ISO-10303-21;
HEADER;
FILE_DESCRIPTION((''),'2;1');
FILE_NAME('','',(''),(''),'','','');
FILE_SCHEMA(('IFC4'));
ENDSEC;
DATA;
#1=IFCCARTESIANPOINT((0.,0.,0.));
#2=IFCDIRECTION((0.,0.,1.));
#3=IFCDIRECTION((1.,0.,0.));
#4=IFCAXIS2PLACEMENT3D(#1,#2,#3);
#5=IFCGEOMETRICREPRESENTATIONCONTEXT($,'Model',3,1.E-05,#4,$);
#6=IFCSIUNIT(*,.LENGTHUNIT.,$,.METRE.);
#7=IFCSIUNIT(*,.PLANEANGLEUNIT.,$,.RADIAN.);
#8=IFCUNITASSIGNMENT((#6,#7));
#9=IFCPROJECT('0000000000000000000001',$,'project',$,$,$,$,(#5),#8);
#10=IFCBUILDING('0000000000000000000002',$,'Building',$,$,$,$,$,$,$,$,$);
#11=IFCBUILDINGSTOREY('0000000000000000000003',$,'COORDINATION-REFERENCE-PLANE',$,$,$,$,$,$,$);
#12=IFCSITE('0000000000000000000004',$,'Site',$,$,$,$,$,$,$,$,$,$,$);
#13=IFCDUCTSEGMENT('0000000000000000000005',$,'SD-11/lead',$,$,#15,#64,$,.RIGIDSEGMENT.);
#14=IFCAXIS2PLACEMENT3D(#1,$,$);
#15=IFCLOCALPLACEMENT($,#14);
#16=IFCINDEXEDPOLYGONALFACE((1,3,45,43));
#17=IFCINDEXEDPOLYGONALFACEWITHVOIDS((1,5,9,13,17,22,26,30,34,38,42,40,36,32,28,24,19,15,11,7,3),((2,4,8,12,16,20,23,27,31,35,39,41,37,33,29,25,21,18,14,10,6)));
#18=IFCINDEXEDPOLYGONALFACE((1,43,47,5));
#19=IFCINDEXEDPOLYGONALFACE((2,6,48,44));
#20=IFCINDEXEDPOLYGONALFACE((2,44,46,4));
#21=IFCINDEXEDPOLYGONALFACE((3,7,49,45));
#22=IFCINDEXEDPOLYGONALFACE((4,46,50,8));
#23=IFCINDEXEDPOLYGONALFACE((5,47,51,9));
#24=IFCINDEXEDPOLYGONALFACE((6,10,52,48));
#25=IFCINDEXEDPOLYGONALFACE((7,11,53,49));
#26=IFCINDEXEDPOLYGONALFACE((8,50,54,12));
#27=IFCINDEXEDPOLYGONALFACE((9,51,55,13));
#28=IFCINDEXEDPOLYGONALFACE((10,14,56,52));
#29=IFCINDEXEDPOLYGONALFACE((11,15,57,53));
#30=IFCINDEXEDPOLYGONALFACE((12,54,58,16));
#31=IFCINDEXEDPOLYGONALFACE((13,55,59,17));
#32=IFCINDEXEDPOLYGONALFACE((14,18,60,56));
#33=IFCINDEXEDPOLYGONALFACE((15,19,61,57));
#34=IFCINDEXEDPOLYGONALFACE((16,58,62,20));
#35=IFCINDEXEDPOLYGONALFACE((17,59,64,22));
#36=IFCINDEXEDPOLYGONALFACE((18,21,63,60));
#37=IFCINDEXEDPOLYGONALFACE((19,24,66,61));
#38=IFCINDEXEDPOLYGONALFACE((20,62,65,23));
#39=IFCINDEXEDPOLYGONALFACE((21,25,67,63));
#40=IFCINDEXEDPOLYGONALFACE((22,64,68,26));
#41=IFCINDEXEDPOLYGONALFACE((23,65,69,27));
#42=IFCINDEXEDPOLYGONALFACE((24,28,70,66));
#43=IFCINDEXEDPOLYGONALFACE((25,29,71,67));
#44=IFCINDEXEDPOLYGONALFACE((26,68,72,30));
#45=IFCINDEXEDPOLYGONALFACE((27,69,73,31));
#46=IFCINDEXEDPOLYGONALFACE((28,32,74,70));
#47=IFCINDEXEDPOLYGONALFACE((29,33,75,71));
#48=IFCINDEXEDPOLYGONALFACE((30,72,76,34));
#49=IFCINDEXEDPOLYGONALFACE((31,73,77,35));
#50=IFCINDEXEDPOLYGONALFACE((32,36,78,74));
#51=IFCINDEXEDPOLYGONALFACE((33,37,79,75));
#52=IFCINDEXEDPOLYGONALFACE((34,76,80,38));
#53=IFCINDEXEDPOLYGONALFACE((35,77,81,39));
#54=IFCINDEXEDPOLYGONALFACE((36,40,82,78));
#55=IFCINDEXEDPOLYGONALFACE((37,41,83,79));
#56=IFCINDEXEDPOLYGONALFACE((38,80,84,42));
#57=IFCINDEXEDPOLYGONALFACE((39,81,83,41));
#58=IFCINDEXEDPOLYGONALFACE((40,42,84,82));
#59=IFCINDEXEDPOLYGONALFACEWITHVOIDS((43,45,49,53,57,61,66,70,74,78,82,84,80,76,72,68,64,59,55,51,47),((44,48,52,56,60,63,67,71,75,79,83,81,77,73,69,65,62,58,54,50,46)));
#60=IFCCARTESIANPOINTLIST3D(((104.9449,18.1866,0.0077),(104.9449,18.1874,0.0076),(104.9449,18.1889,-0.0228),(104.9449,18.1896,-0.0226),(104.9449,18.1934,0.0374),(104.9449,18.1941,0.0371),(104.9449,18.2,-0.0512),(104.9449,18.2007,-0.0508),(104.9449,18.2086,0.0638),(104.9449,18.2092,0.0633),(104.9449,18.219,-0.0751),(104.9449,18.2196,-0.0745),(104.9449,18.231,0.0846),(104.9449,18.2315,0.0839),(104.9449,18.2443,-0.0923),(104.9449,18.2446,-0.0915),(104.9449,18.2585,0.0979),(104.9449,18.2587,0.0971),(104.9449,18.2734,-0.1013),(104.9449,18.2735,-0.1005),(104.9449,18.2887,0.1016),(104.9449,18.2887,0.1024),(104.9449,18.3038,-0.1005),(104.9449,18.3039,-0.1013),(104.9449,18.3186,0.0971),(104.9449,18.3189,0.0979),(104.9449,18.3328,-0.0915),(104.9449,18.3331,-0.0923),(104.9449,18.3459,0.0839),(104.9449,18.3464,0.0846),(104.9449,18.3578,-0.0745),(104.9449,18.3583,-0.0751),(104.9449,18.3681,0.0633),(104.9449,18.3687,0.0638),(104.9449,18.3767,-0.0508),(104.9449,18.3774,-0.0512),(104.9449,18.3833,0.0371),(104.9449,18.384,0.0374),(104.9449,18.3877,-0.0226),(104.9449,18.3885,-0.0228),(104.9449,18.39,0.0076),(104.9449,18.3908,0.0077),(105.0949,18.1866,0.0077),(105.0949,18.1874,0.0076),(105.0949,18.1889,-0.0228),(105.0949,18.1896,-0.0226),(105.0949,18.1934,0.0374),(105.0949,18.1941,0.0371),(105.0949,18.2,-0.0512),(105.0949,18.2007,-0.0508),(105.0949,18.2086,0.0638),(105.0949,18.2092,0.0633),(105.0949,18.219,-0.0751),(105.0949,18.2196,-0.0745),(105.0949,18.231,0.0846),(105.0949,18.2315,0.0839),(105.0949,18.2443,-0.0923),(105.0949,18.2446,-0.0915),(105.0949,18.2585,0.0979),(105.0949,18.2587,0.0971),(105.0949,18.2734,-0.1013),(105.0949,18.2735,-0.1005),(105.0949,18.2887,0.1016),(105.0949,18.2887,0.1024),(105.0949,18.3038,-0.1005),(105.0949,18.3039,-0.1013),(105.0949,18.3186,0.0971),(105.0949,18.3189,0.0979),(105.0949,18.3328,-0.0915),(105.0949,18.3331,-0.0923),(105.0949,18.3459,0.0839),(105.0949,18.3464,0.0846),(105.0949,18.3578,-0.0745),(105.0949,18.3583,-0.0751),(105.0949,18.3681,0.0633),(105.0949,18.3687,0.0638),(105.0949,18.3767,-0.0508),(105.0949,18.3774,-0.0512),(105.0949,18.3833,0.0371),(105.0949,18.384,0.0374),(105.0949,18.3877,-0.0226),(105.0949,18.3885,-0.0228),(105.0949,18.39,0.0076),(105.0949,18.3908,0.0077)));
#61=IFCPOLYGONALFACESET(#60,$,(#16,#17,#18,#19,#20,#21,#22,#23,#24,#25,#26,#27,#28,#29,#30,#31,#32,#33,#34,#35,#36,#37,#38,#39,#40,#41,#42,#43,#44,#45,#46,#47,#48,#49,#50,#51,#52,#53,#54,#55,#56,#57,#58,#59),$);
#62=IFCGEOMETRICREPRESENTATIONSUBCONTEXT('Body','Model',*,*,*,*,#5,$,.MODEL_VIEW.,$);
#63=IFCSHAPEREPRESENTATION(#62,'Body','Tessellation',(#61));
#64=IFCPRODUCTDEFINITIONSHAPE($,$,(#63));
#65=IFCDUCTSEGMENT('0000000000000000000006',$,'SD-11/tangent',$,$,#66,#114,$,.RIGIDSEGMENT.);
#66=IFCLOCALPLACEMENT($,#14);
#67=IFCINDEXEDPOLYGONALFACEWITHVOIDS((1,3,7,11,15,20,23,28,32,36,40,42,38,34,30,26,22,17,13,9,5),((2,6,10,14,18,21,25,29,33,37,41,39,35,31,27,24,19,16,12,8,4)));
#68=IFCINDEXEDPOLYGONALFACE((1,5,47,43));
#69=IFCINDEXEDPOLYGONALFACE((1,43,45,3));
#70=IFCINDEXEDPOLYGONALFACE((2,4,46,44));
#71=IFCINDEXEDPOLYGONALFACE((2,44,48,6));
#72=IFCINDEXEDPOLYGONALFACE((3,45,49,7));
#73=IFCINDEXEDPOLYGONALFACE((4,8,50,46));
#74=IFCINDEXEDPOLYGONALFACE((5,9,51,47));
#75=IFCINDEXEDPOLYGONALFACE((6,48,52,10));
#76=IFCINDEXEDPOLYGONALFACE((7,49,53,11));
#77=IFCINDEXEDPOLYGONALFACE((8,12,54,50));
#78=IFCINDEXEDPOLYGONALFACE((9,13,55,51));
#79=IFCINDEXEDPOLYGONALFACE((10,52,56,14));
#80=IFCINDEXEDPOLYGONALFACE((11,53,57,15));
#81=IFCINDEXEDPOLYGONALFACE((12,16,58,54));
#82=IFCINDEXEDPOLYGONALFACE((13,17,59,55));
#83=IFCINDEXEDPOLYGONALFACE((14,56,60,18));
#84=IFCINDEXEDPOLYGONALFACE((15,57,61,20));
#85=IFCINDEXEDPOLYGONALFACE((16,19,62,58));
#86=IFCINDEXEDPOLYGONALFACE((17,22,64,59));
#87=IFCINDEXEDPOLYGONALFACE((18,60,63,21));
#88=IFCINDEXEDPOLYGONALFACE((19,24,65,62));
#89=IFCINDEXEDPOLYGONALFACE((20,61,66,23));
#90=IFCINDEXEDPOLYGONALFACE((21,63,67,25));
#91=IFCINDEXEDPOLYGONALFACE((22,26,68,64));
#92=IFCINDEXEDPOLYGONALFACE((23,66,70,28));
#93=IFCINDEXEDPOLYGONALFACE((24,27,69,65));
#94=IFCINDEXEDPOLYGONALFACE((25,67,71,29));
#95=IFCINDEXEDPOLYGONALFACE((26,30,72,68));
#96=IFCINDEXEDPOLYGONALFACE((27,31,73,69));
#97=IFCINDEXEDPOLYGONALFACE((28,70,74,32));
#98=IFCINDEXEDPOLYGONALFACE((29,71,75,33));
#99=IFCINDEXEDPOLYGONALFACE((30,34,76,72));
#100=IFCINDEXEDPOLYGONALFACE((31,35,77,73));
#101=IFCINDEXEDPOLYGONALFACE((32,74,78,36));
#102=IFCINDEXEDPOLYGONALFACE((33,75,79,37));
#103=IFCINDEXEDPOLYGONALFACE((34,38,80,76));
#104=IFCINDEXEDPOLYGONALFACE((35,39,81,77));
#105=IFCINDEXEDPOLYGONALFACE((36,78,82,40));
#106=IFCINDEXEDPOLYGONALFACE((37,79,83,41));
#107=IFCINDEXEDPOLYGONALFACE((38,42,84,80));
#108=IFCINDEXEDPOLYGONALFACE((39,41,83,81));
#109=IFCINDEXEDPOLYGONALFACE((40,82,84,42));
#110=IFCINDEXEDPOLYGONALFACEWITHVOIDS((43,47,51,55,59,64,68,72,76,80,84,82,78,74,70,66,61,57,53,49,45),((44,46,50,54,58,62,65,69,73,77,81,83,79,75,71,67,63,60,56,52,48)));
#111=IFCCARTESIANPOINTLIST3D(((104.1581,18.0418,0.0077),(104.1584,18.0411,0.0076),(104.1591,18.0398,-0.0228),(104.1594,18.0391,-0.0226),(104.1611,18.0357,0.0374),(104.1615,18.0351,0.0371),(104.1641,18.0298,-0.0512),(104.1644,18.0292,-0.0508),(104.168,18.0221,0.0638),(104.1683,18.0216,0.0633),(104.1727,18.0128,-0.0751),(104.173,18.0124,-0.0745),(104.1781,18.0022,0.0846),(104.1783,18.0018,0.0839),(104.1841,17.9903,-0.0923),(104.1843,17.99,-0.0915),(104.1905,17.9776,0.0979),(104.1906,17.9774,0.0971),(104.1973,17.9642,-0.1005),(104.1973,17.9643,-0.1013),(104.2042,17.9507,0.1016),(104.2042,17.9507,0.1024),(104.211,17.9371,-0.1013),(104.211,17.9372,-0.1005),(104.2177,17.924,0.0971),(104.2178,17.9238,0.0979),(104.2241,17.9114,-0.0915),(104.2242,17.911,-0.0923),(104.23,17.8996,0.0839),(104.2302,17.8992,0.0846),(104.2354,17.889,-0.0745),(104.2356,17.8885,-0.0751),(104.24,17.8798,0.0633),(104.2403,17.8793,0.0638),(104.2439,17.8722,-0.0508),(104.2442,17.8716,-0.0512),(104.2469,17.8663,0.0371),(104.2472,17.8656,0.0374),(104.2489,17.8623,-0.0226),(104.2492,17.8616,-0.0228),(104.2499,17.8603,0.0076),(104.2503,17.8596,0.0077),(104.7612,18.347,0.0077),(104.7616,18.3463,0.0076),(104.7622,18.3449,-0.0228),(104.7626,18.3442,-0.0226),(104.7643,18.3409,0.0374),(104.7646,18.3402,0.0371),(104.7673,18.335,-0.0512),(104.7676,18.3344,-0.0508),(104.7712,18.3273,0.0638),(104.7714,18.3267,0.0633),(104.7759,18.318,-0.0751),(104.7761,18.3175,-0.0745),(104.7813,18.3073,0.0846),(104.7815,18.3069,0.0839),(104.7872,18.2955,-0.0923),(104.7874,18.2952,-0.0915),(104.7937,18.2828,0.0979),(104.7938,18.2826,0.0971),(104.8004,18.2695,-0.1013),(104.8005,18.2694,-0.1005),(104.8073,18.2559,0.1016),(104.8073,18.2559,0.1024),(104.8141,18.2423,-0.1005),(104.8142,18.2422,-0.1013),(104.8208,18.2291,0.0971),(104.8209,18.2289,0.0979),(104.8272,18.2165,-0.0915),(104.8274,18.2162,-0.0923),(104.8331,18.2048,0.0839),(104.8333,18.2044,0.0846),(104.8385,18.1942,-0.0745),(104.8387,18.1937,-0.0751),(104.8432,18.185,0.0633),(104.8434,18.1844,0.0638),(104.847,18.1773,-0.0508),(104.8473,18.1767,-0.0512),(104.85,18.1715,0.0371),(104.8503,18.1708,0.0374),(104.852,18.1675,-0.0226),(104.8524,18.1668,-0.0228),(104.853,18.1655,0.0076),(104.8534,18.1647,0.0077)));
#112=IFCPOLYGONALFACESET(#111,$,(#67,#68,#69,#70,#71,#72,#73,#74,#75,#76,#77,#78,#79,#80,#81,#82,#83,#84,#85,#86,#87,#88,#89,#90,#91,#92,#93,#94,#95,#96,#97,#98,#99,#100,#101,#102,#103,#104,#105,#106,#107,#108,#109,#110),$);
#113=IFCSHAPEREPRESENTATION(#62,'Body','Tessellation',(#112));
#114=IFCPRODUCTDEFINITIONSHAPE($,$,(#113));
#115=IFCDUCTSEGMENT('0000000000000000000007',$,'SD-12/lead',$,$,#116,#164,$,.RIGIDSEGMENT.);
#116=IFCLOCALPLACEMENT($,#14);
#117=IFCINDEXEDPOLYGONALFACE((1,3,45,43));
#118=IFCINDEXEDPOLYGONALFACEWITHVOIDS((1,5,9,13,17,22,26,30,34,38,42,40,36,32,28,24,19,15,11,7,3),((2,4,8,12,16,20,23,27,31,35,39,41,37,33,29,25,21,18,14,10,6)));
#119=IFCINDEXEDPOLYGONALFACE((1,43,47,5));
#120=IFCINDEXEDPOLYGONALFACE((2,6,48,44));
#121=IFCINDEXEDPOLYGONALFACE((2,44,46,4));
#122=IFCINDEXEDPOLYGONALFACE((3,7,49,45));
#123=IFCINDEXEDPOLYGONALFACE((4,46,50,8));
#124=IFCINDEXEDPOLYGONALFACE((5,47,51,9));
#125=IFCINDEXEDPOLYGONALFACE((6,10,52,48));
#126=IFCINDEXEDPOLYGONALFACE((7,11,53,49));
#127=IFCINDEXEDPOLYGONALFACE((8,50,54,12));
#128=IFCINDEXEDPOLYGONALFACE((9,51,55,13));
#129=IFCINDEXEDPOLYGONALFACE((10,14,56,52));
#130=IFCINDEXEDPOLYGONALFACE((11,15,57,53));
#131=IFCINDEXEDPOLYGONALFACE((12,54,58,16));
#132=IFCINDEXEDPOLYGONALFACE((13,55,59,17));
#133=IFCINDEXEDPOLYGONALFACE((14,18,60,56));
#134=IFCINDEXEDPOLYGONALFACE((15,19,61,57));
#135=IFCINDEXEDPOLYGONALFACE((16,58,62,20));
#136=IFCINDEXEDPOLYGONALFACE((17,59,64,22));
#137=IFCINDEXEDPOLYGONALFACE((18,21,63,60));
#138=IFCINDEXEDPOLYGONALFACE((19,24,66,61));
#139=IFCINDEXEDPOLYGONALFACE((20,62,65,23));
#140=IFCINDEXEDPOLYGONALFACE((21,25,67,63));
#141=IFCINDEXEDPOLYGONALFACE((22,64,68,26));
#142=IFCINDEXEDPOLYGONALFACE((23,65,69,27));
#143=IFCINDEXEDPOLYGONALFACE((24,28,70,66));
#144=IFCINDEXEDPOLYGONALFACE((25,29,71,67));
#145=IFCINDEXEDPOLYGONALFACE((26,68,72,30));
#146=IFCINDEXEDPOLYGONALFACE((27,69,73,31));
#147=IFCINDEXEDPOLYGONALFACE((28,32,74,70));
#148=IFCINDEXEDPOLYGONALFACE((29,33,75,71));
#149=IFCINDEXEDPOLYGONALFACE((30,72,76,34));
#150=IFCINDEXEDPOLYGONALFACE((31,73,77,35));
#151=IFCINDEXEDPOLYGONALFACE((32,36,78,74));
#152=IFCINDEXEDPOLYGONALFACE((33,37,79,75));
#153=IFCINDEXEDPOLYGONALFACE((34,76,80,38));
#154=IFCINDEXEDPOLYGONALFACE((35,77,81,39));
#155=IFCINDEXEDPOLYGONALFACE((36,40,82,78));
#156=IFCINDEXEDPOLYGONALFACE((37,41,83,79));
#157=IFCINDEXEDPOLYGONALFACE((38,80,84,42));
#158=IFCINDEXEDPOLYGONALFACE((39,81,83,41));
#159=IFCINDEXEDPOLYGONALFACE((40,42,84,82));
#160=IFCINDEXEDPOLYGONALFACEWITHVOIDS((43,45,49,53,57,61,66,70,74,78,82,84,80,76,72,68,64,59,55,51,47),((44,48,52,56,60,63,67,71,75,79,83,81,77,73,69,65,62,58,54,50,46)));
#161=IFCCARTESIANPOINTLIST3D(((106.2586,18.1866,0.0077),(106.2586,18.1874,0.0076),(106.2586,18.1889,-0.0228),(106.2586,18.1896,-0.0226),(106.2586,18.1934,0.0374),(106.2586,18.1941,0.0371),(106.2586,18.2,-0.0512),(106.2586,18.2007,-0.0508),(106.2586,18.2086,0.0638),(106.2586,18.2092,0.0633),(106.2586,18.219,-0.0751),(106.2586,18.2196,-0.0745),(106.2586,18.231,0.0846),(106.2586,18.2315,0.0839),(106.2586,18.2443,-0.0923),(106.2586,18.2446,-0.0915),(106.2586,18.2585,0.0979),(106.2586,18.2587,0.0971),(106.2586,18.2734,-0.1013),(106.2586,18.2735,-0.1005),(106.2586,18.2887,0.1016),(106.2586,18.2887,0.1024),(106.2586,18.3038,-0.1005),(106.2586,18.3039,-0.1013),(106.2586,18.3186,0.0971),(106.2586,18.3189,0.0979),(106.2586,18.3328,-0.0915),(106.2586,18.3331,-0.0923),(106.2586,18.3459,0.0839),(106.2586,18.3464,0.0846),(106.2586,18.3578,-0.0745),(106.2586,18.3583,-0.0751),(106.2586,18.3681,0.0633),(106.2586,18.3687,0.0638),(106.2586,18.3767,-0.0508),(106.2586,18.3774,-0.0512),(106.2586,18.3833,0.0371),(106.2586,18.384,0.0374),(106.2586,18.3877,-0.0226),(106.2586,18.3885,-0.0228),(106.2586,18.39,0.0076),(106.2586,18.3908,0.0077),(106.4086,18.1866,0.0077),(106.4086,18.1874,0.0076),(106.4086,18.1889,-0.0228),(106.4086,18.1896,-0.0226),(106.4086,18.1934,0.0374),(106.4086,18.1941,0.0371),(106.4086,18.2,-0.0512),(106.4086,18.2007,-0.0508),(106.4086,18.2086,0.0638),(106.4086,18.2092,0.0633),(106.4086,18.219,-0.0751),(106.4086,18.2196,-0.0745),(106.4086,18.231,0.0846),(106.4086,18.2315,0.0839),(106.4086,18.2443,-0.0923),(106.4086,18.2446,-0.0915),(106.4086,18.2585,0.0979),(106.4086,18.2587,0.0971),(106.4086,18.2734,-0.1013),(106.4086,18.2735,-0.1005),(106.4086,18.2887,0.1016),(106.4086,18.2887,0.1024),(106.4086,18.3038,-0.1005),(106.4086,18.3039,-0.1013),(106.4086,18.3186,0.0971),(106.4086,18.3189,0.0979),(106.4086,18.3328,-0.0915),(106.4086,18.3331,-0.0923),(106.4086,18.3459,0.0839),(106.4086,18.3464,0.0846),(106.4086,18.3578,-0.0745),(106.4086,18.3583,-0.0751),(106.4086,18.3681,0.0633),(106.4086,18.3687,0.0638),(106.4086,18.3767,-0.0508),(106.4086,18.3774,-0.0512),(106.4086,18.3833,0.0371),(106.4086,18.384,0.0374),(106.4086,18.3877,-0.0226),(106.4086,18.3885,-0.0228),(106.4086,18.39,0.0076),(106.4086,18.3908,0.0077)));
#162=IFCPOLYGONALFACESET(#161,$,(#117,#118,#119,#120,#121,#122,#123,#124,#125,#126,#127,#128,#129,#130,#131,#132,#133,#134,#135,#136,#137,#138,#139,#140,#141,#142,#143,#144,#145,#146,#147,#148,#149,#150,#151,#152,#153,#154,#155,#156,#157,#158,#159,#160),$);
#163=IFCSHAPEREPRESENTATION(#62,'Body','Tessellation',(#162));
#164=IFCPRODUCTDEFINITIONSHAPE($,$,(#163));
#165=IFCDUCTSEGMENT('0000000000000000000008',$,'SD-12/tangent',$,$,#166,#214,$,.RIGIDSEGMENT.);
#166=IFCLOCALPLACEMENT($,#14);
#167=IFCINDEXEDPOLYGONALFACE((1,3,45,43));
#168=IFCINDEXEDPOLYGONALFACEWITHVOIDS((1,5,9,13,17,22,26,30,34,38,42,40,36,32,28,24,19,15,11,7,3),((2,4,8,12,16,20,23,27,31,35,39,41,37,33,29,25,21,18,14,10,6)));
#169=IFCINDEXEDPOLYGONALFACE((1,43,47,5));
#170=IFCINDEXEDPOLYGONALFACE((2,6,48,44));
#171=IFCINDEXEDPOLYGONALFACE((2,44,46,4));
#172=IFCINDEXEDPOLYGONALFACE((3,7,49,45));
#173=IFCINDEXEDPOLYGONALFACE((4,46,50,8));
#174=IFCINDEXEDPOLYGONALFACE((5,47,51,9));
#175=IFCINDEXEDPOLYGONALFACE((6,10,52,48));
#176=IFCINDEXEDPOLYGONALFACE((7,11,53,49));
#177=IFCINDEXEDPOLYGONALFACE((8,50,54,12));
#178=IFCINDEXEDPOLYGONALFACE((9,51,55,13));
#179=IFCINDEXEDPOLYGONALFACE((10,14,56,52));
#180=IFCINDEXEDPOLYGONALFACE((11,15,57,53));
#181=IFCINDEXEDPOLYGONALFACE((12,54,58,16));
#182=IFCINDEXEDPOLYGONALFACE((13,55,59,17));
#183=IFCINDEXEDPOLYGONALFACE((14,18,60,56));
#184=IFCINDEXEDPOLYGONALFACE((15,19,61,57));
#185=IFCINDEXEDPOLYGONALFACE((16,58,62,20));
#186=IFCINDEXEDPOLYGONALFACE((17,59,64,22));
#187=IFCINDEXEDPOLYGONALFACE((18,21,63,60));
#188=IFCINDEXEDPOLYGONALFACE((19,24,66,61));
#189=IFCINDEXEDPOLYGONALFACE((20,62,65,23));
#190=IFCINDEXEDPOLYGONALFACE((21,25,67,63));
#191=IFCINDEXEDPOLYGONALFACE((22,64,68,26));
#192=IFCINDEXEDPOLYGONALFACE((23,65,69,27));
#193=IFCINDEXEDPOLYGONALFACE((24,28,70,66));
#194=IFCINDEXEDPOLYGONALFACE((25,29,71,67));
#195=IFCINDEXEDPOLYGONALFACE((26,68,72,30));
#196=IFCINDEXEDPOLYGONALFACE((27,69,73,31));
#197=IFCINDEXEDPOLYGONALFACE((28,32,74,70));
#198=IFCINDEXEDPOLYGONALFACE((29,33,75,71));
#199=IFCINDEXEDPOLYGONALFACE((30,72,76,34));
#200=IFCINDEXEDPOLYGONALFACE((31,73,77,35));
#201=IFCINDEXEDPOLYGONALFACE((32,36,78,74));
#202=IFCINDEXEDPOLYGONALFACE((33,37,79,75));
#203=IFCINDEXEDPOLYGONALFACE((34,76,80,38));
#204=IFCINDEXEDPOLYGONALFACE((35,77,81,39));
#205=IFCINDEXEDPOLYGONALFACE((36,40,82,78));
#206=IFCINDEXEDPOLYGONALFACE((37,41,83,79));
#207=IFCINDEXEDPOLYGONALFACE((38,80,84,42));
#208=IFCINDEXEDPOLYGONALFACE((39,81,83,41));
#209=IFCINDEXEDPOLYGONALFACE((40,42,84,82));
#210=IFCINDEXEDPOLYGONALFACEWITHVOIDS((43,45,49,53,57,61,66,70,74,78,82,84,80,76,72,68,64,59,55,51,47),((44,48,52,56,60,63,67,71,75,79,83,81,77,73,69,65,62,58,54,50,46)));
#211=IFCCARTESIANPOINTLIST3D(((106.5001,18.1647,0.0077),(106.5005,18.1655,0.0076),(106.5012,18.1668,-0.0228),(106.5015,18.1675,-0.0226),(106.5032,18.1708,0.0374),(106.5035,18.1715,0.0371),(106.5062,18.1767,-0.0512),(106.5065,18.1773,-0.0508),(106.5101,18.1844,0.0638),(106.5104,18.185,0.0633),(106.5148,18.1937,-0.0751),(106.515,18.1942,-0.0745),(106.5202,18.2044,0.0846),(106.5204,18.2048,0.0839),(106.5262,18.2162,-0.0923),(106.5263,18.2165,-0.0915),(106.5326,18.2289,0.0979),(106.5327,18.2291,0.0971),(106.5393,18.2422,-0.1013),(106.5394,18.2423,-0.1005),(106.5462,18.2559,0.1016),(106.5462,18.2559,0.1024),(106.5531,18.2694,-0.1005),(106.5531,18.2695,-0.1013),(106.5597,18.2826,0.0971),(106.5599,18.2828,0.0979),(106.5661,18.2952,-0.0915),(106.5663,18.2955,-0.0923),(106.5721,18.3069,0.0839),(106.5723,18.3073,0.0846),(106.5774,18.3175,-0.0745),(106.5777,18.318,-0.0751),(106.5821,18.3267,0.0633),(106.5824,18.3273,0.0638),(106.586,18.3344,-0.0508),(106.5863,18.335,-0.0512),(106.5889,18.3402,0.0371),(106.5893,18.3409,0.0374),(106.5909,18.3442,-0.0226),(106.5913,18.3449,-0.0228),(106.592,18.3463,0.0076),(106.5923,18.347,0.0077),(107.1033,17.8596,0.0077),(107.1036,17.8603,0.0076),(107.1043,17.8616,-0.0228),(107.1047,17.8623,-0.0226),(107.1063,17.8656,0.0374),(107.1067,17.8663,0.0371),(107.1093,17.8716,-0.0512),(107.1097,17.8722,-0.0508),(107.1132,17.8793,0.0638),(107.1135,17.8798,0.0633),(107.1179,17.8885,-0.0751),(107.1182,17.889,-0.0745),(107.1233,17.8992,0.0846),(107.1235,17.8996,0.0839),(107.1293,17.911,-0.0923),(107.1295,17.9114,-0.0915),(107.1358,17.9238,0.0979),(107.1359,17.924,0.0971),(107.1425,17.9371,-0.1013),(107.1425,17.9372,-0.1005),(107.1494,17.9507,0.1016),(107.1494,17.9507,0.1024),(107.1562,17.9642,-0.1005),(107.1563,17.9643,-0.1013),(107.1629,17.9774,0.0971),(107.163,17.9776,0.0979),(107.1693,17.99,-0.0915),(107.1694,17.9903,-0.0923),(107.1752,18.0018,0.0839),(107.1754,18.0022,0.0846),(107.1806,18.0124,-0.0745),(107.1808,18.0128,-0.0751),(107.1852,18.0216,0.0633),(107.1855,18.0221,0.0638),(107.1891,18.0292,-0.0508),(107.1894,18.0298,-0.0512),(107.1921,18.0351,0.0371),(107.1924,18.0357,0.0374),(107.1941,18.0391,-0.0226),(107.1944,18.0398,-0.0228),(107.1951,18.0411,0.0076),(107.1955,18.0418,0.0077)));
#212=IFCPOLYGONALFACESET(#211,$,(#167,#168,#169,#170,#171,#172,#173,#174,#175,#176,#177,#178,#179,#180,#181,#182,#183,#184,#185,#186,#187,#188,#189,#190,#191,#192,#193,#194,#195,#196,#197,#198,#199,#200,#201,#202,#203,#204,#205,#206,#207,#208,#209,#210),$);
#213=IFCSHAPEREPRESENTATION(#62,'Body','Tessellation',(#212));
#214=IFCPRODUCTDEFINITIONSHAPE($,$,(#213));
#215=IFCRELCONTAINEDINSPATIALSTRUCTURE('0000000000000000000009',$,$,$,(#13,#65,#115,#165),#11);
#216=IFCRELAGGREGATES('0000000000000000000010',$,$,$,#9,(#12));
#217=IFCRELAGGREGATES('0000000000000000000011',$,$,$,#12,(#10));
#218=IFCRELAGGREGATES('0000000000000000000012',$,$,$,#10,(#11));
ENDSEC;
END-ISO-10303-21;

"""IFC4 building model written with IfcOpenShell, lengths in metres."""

from ifc_helpers import new_model, si_unit, frame, origin_with_axes, place, context, subcontext, project, spatial, hollow_circle, extrude, element, save


model = new_model("IFC4")

# Units and contexts
model_context_1 = context("Model", 3, precision=1e-05, world=origin_with_axes())
body_context_1 = subcontext(model_context_1, "Body", "Model", "MODEL_VIEW")
ifc_project = project(units=[si_unit("LENGTHUNIT", "METRE"), si_unit("PLANEANGLEUNIT", "RADIAN")], contexts=[model_context_1])

# Site, building, storey
site = spatial("IfcSite", under=ifc_project, Name="Site")
building = spatial("IfcBuilding", under=site, Name="Building")
storey = spatial("IfcBuildingStorey", under=building, Name="COORDINATION-REFERENCE-PLANE")

# Duct segment
duct_segment_1_placement = place(None, frame((105.0949, 18.2887, 0.0), z_axis=(-1.0, 0.0, 0.0), x_axis=(0.0, 0.0, 1.0)))
element("IfcDuctSegment", 1, at=duct_segment_1_placement, inside=storey, Name="SD-11/lead", PredefinedType="RIGIDSEGMENT", context=body_context_1, shape_type="SweptSolid", body=[
    extrude(hollow_circle(Radius=0.1024, WallThickness=0.0008), origin_with_axes(), (0.0, 0.0, 1.0), 0.15),
])

# Duct segment
duct_segment_2_placement = place(None, frame((104.8073, 18.2559, 0.0), z_axis=(-0.892292, -0.451458, 0.0), x_axis=(0.0, 0.0, 1.0)))
element("IfcDuctSegment", 2, at=duct_segment_2_placement, inside=storey, Name="SD-11/tangent", PredefinedType="RIGIDSEGMENT", context=body_context_1, shape_type="SweptSolid", body=[
    extrude(hollow_circle(Radius=0.1024, WallThickness=0.0008), origin_with_axes(), (0.0, 0.0, 1.0), 0.676),
])

# Duct segment
duct_segment_3_placement = place(None, frame((106.2586, 18.2887, 0.0), z_axis=(1.0, 0.0, 0.0), x_axis=(0.0, 0.0, 1.0)))
element("IfcDuctSegment", 3, at=duct_segment_3_placement, inside=storey, Name="SD-12/lead", PredefinedType="RIGIDSEGMENT", context=body_context_1, shape_type="SweptSolid", body=[
    extrude(hollow_circle(Radius=0.1024, WallThickness=0.0008), origin_with_axes(), (0.0, 0.0, 1.0), 0.15),
])

# Duct segment
duct_segment_4_placement = place(None, frame((106.5462, 18.2559, 0.0), z_axis=(0.892292, -0.451458, 0.0), x_axis=(0.0, 0.0, 1.0)))
element("IfcDuctSegment", 4, at=duct_segment_4_placement, inside=storey, Name="SD-12/tangent", PredefinedType="RIGIDSEGMENT", context=body_context_1, shape_type="SweptSolid", body=[
    extrude(hollow_circle(Radius=0.1024, WallThickness=0.0008), origin_with_axes(), (0.0, 0.0, 1.0), 0.676),
])

save(model, "model.ifc")
